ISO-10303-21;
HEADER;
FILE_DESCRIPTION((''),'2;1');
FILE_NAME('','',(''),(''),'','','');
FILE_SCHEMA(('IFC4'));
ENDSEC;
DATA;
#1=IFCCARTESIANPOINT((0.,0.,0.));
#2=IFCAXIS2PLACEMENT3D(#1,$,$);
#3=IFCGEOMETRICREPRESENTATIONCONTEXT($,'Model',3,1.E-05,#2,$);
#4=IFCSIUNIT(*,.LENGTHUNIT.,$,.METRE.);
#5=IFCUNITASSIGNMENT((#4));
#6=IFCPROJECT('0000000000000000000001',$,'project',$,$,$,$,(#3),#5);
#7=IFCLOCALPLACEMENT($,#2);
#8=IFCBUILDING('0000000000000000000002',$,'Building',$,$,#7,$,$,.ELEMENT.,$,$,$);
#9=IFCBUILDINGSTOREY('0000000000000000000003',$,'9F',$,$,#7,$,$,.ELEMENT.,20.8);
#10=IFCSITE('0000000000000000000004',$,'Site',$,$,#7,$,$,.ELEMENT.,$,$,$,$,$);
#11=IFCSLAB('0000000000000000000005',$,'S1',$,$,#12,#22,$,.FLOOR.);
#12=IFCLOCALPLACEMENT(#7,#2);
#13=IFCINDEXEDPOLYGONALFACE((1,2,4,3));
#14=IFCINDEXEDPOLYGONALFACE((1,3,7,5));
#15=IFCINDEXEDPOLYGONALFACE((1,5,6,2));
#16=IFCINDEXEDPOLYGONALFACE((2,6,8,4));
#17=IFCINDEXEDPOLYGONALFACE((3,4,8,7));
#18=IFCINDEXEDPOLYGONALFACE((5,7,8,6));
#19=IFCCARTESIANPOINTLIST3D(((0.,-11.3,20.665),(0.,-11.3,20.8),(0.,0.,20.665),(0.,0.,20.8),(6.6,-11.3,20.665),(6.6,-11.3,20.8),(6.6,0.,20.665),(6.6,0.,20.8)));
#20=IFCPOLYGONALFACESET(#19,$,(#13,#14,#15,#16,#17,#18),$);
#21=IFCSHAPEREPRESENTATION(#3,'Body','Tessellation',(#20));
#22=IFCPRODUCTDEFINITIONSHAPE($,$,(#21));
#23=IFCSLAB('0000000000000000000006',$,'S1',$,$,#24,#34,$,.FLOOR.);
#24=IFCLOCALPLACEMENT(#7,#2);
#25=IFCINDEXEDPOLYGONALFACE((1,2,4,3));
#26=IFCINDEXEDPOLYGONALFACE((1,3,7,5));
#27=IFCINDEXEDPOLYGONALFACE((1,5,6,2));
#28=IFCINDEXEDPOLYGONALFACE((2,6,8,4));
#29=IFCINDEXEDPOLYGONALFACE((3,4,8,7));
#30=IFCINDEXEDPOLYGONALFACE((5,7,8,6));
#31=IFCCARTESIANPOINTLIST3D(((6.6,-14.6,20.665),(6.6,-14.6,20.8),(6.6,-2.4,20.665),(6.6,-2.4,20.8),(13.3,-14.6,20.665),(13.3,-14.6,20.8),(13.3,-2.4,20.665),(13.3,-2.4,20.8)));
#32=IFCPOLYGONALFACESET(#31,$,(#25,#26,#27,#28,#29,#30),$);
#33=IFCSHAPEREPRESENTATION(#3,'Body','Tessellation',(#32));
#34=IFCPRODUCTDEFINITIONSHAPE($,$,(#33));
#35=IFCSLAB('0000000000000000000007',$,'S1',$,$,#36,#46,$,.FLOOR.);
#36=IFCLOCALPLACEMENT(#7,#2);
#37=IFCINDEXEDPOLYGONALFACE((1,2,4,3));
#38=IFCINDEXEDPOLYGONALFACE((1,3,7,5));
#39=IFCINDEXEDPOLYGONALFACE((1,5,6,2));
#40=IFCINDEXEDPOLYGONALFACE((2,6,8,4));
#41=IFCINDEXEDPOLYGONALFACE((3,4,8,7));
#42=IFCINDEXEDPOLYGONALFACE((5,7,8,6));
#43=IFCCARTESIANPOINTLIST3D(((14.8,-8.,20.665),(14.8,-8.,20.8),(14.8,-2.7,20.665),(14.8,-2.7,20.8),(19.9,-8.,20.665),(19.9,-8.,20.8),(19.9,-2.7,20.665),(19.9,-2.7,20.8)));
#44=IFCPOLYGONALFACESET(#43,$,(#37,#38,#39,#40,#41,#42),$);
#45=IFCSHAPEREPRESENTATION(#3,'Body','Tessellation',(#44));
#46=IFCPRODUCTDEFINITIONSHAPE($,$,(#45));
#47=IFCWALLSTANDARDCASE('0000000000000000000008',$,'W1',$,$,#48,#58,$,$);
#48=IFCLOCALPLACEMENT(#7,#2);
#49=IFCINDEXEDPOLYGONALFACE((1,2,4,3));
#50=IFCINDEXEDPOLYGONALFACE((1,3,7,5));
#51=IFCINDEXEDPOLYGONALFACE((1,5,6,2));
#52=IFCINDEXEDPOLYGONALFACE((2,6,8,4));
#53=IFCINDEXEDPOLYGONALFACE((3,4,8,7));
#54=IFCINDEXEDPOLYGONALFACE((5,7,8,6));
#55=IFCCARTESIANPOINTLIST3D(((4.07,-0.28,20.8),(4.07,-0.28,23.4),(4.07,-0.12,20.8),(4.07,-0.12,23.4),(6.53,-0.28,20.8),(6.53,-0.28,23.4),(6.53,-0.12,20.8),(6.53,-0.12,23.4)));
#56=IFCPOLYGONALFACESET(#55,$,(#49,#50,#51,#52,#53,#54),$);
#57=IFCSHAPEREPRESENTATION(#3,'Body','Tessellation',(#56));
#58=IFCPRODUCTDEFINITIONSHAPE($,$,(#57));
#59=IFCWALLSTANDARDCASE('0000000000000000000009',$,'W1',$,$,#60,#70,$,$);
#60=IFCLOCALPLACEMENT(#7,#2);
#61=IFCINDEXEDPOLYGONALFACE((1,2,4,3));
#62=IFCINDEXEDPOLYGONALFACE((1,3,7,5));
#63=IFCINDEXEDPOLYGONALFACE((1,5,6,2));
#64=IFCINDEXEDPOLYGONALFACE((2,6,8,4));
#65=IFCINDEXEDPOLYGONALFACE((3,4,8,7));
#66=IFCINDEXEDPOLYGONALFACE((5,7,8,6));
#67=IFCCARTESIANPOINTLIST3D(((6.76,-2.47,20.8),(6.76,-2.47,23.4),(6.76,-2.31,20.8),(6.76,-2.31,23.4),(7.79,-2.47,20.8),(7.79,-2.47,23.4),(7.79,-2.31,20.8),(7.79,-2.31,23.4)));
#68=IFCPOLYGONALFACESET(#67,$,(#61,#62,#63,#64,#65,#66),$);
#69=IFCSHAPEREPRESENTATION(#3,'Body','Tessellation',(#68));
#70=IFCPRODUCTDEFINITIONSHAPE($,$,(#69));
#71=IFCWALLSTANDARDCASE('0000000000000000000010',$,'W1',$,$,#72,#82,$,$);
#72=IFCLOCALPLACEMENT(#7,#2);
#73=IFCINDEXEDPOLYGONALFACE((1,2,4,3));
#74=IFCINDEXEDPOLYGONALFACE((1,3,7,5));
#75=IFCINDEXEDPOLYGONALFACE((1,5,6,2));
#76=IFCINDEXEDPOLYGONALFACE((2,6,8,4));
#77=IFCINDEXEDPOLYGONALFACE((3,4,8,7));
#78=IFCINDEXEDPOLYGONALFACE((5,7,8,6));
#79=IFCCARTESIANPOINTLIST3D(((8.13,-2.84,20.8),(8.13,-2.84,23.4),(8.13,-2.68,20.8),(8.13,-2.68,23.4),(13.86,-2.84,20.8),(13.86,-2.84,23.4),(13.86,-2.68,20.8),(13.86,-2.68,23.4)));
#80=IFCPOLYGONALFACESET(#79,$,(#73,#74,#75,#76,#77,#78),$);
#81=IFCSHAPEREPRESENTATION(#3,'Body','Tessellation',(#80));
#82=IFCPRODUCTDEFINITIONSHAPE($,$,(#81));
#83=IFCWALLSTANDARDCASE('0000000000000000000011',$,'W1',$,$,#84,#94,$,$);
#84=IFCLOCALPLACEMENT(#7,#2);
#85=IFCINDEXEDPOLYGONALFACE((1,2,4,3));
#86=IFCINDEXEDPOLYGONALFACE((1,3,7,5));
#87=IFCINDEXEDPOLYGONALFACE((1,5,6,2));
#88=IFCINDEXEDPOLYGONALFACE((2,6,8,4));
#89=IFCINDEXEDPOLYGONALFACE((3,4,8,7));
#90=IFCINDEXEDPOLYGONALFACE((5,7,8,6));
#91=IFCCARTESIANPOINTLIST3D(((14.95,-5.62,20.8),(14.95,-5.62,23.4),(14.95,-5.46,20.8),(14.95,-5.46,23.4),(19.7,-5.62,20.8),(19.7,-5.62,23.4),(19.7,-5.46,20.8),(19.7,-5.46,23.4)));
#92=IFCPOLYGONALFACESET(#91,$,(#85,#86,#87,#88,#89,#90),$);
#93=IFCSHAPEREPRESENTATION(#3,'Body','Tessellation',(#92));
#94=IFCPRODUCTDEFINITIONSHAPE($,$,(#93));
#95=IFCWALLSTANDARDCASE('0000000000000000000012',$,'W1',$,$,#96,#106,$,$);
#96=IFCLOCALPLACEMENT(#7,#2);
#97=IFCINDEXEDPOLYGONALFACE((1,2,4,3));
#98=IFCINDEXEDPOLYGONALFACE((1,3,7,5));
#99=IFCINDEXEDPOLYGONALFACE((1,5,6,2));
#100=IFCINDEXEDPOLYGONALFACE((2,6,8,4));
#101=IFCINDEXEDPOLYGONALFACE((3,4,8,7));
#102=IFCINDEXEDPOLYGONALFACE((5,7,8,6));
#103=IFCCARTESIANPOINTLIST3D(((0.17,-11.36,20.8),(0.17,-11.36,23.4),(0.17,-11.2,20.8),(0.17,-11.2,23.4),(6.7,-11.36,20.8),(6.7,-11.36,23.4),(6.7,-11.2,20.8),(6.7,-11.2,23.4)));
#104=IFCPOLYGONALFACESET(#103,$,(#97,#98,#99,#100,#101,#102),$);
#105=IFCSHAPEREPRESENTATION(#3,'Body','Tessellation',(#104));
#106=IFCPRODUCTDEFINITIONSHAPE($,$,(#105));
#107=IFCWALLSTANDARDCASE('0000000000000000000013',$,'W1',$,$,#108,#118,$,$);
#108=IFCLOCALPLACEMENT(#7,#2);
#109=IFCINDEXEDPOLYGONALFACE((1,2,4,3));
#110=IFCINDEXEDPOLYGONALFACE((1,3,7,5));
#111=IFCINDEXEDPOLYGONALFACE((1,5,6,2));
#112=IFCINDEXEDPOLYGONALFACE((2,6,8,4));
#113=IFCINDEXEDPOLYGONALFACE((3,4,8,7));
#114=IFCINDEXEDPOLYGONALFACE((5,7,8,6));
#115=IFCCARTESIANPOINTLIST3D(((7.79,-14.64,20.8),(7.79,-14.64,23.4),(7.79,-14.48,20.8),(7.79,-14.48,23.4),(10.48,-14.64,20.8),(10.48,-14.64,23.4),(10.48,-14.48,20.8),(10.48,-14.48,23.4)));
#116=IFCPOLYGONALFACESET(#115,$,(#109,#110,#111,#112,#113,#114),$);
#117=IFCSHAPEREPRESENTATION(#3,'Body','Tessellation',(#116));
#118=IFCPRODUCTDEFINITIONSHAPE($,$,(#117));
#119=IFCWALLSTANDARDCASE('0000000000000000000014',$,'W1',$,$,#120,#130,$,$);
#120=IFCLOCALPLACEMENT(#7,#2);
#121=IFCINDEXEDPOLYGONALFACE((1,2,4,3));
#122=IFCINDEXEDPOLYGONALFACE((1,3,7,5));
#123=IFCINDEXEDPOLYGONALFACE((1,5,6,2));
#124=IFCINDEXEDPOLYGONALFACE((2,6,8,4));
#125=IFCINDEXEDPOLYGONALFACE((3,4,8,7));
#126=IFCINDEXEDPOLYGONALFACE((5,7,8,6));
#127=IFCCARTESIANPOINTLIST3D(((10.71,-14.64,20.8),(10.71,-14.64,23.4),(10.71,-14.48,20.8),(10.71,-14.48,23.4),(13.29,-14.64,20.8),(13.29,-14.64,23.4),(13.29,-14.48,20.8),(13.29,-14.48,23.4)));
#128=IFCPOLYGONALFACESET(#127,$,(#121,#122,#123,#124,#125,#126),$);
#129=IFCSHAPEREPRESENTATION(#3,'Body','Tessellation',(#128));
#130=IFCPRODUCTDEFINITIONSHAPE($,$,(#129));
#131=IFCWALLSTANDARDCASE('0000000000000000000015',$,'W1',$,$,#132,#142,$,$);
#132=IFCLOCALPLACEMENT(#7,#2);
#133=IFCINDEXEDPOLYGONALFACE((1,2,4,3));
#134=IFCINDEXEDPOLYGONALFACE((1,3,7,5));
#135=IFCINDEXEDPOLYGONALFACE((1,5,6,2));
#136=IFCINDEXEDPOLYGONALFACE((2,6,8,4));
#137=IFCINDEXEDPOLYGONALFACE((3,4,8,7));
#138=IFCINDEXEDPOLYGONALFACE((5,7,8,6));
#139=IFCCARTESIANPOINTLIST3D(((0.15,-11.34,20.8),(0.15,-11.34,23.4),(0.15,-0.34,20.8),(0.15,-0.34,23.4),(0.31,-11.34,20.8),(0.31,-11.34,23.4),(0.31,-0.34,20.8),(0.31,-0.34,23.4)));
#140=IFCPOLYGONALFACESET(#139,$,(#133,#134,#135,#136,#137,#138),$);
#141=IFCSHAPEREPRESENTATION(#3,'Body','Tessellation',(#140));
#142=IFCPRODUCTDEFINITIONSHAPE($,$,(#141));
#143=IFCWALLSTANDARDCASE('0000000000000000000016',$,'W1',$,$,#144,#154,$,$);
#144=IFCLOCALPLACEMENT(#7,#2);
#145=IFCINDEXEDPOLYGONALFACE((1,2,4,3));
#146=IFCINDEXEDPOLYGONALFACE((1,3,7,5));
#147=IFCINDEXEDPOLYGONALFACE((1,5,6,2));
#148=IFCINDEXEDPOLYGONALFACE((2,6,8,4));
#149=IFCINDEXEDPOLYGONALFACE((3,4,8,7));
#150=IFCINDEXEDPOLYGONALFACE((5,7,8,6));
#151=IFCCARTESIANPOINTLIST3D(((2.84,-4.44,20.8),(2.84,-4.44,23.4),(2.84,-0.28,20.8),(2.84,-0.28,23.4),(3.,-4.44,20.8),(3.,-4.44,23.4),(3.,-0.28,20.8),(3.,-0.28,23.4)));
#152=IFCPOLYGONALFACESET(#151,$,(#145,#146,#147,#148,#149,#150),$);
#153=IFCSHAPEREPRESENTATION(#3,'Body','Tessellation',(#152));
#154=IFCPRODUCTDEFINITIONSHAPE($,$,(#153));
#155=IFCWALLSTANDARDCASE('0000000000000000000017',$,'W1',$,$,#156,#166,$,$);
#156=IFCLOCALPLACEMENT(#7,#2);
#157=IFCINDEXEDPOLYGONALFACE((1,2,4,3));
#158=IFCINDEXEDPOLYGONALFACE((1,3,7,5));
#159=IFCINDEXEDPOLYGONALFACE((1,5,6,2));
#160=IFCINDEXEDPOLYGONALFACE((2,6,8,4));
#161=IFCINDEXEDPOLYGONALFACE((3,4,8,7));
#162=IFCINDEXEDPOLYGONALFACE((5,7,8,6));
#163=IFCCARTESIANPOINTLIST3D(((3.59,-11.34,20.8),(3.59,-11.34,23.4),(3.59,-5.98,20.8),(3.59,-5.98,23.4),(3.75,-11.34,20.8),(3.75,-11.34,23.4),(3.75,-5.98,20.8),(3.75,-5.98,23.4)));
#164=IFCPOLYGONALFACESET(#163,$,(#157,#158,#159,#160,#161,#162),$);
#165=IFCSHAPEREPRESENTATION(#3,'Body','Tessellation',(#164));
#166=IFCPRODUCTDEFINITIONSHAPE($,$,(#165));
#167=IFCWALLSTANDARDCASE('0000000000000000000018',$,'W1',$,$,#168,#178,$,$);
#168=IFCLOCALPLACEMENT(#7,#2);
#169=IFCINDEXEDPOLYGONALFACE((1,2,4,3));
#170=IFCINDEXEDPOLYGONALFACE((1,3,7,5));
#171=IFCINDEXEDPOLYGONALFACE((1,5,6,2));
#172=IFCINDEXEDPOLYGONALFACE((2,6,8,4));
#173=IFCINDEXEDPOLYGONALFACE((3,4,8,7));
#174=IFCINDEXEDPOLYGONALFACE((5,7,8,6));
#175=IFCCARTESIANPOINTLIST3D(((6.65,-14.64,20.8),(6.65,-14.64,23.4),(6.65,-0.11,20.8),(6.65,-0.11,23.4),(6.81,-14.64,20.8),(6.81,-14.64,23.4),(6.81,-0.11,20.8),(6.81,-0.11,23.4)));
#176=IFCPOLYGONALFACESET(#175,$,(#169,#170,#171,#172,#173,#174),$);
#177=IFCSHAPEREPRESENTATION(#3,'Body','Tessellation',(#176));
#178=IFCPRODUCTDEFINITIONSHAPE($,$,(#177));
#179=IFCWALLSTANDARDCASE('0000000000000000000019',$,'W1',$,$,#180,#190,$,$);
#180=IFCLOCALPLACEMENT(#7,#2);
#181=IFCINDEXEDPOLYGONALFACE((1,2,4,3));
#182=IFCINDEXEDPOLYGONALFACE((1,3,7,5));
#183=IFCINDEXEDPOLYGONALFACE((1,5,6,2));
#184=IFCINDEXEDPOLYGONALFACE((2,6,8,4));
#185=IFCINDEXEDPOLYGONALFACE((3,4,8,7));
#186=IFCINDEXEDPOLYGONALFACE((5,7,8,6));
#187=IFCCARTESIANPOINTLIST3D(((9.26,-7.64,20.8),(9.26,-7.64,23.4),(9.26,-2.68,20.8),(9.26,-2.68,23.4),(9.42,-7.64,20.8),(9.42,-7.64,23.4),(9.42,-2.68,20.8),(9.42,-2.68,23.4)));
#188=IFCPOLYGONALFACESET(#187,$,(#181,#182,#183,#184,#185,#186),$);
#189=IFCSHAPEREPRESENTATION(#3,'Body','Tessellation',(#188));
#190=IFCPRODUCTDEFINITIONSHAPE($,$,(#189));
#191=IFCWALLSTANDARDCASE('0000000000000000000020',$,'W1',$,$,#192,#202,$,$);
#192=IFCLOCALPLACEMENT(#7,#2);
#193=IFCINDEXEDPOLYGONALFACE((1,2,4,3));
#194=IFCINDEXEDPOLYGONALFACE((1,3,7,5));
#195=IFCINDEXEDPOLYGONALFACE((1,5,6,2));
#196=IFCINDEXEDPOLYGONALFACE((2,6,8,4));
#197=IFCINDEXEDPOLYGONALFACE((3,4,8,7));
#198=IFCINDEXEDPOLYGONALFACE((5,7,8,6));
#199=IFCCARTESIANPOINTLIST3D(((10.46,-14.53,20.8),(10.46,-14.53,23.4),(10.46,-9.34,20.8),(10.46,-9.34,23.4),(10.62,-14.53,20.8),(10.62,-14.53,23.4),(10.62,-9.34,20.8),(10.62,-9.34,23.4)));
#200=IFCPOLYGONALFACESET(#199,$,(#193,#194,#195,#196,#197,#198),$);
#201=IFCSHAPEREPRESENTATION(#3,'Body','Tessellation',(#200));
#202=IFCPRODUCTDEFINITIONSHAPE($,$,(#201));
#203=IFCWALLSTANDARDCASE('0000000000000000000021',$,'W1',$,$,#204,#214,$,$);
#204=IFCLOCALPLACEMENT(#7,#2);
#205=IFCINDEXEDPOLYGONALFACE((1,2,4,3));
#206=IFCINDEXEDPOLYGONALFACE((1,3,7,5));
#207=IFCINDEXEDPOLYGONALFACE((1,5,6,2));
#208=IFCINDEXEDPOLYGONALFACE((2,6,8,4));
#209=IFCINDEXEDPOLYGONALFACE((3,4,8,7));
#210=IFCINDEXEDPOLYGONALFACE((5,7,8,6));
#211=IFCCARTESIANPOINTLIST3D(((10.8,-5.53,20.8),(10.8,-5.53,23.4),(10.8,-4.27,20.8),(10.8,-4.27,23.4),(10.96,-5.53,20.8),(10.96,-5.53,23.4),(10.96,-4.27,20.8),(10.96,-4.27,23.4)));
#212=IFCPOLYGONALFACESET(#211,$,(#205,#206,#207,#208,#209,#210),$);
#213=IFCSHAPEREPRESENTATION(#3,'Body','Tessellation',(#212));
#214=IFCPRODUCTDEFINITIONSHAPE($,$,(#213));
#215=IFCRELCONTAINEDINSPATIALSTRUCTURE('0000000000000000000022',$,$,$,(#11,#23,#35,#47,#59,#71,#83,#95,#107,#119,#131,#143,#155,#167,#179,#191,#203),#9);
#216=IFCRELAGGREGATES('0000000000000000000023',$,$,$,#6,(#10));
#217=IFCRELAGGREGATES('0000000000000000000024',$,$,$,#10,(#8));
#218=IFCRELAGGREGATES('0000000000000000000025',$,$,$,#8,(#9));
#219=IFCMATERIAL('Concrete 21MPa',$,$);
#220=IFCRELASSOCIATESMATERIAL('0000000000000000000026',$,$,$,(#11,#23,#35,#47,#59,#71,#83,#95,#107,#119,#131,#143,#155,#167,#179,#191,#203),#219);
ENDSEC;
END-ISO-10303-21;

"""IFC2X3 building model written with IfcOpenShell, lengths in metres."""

from ifc_helpers import new_model, si_unit, frame, origin, origin_2d, place, context, project, spatial, rectangle, extrude, material, element, save


model = new_model("IFC2X3")

# Units and contexts
model_context = context("Model", 3, precision=1e-05, world=origin())
ifc_project = project(units=[si_unit("LENGTHUNIT", "METRE")], contexts=[model_context])

# Site, building, storey
placement = place(None, origin())
site = spatial("IfcSite", under=ifc_project, at=placement, Name="Site", CompositionType="ELEMENT")
building = spatial("IfcBuilding", under=site, at=placement, Name="Building", CompositionType="ELEMENT")
storey = spatial("IfcBuildingStorey", under=building, at=placement, Name="9F", CompositionType="ELEMENT", Elevation=20.8)

# Slabs
ifc_material_1 = material(Name="Concrete 21MPa")
slab_1_placement = place(None, frame((3.3, -5.65, 20.665)))
element("IfcSlab", 1, at=slab_1_placement, inside=storey, material=ifc_material_1, Name="S1", PredefinedType="FLOOR", context=model_context, shape_type="SweptSolid", body=[
    extrude(rectangle(XDim=6.6, YDim=11.3, at=origin_2d()), origin(), (0.0, 0.0, 1.0), 0.135),
])
slab_2_placement = place(None, frame((9.95, -8.5, 20.665)))
element("IfcSlab", 2, at=slab_2_placement, inside=storey, material=ifc_material_1, Name="S1", PredefinedType="FLOOR", context=model_context, shape_type="SweptSolid", body=[
    extrude(rectangle(XDim=6.7, YDim=12.2, at=origin_2d()), origin(), (0.0, 0.0, 1.0), 0.135),
])
slab_3_placement = place(None, frame((17.35, -5.35, 20.665)))
element("IfcSlab", 3, at=slab_3_placement, inside=storey, material=ifc_material_1, Name="S1", PredefinedType="FLOOR", context=model_context, shape_type="SweptSolid", body=[
    extrude(rectangle(XDim=5.1, YDim=5.3, at=origin_2d()), origin(), (0.0, 0.0, 1.0), 0.135),
])

# Walls
wall_1_placement = place(None, frame((5.3, -0.2, 20.8)))
element("IfcWallStandardCase", 4, at=wall_1_placement, inside=storey, material=ifc_material_1, Name="W1", context=model_context, shape_type="SweptSolid", body=[
    extrude(rectangle(XDim=2.46, YDim=0.16, at=origin_2d()), origin(), (0.0, 0.0, 1.0), 2.6),
])
wall_2_placement = place(None, frame((7.275, -2.39, 20.8)))
element("IfcWallStandardCase", 5, at=wall_2_placement, inside=storey, material=ifc_material_1, Name="W1", context=model_context, shape_type="SweptSolid", body=[
    extrude(rectangle(XDim=1.03, YDim=0.16, at=origin_2d()), origin(), (0.0, 0.0, 1.0), 2.6),
])
wall_3_placement = place(None, frame((10.995, -2.76, 20.8)))
element("IfcWallStandardCase", 6, at=wall_3_placement, inside=storey, material=ifc_material_1, Name="W1", context=model_context, shape_type="SweptSolid", body=[
    extrude(rectangle(XDim=5.73, YDim=0.16, at=origin_2d()), origin(), (0.0, 0.0, 1.0), 2.6),
])
wall_4_placement = place(None, frame((17.325, -5.54, 20.8)))
element("IfcWallStandardCase", 7, at=wall_4_placement, inside=storey, material=ifc_material_1, Name="W1", context=model_context, shape_type="SweptSolid", body=[
    extrude(rectangle(XDim=4.75, YDim=0.16, at=origin_2d()), origin(), (0.0, 0.0, 1.0), 2.6),
])
wall_5_placement = place(None, frame((3.435, -11.28, 20.8)))
element("IfcWallStandardCase", 8, at=wall_5_placement, inside=storey, material=ifc_material_1, Name="W1", context=model_context, shape_type="SweptSolid", body=[
    extrude(rectangle(XDim=6.53, YDim=0.16, at=origin_2d()), origin(), (0.0, 0.0, 1.0), 2.6),
])
wall_6_placement = place(None, frame((9.135, -14.56, 20.8)))
element("IfcWallStandardCase", 9, at=wall_6_placement, inside=storey, material=ifc_material_1, Name="W1", context=model_context, shape_type="SweptSolid", body=[
    extrude(rectangle(XDim=2.69, YDim=0.16, at=origin_2d()), origin(), (0.0, 0.0, 1.0), 2.6),
])
wall_7_placement = place(None, frame((12.0, -14.56, 20.8)))
element("IfcWallStandardCase", 10, at=wall_7_placement, inside=storey, material=ifc_material_1, Name="W1", context=model_context, shape_type="SweptSolid", body=[
    extrude(rectangle(XDim=2.58, YDim=0.16, at=origin_2d()), origin(), (0.0, 0.0, 1.0), 2.6),
])
wall_8_placement = place(None, frame((0.23, -5.84, 20.8)))
element("IfcWallStandardCase", 11, at=wall_8_placement, inside=storey, material=ifc_material_1, Name="W1", context=model_context, shape_type="SweptSolid", body=[
    extrude(rectangle(XDim=0.16, YDim=11.0, at=origin_2d()), origin(), (0.0, 0.0, 1.0), 2.6),
])
wall_9_placement = place(None, frame((2.92, -2.36, 20.8)))
element("IfcWallStandardCase", 12, at=wall_9_placement, inside=storey, material=ifc_material_1, Name="W1", context=model_context, shape_type="SweptSolid", body=[
    extrude(rectangle(XDim=0.16, YDim=4.16, at=origin_2d()), origin(), (0.0, 0.0, 1.0), 2.6),
])
wall_10_placement = place(None, frame((3.67, -8.66, 20.8)))
element("IfcWallStandardCase", 13, at=wall_10_placement, inside=storey, material=ifc_material_1, Name="W1", context=model_context, shape_type="SweptSolid", body=[
    extrude(rectangle(XDim=0.16, YDim=5.36, at=origin_2d()), origin(), (0.0, 0.0, 1.0), 2.6),
])
wall_11_placement = place(None, frame((6.73, -7.375, 20.8)))
element("IfcWallStandardCase", 14, at=wall_11_placement, inside=storey, material=ifc_material_1, Name="W1", context=model_context, shape_type="SweptSolid", body=[
    extrude(rectangle(XDim=0.16, YDim=14.53, at=origin_2d()), origin(), (0.0, 0.0, 1.0), 2.6),
])
wall_12_placement = place(None, frame((9.34, -5.16, 20.8)))
element("IfcWallStandardCase", 15, at=wall_12_placement, inside=storey, material=ifc_material_1, Name="W1", context=model_context, shape_type="SweptSolid", body=[
    extrude(rectangle(XDim=0.16, YDim=4.96, at=origin_2d()), origin(), (0.0, 0.0, 1.0), 2.6),
])
wall_13_placement = place(None, frame((10.54, -11.935, 20.8)))
element("IfcWallStandardCase", 16, at=wall_13_placement, inside=storey, material=ifc_material_1, Name="W1", context=model_context, shape_type="SweptSolid", body=[
    extrude(rectangle(XDim=0.16, YDim=5.19, at=origin_2d()), origin(), (0.0, 0.0, 1.0), 2.6),
])
wall_14_placement = place(None, frame((10.88, -4.9, 20.8)))
element("IfcWallStandardCase", 17, at=wall_14_placement, inside=storey, material=ifc_material_1, Name="W1", context=model_context, shape_type="SweptSolid", body=[
    extrude(rectangle(XDim=0.16, YDim=1.26, at=origin_2d()), origin(), (0.0, 0.0, 1.0), 2.6),
])

save(model, "model.ifc")
